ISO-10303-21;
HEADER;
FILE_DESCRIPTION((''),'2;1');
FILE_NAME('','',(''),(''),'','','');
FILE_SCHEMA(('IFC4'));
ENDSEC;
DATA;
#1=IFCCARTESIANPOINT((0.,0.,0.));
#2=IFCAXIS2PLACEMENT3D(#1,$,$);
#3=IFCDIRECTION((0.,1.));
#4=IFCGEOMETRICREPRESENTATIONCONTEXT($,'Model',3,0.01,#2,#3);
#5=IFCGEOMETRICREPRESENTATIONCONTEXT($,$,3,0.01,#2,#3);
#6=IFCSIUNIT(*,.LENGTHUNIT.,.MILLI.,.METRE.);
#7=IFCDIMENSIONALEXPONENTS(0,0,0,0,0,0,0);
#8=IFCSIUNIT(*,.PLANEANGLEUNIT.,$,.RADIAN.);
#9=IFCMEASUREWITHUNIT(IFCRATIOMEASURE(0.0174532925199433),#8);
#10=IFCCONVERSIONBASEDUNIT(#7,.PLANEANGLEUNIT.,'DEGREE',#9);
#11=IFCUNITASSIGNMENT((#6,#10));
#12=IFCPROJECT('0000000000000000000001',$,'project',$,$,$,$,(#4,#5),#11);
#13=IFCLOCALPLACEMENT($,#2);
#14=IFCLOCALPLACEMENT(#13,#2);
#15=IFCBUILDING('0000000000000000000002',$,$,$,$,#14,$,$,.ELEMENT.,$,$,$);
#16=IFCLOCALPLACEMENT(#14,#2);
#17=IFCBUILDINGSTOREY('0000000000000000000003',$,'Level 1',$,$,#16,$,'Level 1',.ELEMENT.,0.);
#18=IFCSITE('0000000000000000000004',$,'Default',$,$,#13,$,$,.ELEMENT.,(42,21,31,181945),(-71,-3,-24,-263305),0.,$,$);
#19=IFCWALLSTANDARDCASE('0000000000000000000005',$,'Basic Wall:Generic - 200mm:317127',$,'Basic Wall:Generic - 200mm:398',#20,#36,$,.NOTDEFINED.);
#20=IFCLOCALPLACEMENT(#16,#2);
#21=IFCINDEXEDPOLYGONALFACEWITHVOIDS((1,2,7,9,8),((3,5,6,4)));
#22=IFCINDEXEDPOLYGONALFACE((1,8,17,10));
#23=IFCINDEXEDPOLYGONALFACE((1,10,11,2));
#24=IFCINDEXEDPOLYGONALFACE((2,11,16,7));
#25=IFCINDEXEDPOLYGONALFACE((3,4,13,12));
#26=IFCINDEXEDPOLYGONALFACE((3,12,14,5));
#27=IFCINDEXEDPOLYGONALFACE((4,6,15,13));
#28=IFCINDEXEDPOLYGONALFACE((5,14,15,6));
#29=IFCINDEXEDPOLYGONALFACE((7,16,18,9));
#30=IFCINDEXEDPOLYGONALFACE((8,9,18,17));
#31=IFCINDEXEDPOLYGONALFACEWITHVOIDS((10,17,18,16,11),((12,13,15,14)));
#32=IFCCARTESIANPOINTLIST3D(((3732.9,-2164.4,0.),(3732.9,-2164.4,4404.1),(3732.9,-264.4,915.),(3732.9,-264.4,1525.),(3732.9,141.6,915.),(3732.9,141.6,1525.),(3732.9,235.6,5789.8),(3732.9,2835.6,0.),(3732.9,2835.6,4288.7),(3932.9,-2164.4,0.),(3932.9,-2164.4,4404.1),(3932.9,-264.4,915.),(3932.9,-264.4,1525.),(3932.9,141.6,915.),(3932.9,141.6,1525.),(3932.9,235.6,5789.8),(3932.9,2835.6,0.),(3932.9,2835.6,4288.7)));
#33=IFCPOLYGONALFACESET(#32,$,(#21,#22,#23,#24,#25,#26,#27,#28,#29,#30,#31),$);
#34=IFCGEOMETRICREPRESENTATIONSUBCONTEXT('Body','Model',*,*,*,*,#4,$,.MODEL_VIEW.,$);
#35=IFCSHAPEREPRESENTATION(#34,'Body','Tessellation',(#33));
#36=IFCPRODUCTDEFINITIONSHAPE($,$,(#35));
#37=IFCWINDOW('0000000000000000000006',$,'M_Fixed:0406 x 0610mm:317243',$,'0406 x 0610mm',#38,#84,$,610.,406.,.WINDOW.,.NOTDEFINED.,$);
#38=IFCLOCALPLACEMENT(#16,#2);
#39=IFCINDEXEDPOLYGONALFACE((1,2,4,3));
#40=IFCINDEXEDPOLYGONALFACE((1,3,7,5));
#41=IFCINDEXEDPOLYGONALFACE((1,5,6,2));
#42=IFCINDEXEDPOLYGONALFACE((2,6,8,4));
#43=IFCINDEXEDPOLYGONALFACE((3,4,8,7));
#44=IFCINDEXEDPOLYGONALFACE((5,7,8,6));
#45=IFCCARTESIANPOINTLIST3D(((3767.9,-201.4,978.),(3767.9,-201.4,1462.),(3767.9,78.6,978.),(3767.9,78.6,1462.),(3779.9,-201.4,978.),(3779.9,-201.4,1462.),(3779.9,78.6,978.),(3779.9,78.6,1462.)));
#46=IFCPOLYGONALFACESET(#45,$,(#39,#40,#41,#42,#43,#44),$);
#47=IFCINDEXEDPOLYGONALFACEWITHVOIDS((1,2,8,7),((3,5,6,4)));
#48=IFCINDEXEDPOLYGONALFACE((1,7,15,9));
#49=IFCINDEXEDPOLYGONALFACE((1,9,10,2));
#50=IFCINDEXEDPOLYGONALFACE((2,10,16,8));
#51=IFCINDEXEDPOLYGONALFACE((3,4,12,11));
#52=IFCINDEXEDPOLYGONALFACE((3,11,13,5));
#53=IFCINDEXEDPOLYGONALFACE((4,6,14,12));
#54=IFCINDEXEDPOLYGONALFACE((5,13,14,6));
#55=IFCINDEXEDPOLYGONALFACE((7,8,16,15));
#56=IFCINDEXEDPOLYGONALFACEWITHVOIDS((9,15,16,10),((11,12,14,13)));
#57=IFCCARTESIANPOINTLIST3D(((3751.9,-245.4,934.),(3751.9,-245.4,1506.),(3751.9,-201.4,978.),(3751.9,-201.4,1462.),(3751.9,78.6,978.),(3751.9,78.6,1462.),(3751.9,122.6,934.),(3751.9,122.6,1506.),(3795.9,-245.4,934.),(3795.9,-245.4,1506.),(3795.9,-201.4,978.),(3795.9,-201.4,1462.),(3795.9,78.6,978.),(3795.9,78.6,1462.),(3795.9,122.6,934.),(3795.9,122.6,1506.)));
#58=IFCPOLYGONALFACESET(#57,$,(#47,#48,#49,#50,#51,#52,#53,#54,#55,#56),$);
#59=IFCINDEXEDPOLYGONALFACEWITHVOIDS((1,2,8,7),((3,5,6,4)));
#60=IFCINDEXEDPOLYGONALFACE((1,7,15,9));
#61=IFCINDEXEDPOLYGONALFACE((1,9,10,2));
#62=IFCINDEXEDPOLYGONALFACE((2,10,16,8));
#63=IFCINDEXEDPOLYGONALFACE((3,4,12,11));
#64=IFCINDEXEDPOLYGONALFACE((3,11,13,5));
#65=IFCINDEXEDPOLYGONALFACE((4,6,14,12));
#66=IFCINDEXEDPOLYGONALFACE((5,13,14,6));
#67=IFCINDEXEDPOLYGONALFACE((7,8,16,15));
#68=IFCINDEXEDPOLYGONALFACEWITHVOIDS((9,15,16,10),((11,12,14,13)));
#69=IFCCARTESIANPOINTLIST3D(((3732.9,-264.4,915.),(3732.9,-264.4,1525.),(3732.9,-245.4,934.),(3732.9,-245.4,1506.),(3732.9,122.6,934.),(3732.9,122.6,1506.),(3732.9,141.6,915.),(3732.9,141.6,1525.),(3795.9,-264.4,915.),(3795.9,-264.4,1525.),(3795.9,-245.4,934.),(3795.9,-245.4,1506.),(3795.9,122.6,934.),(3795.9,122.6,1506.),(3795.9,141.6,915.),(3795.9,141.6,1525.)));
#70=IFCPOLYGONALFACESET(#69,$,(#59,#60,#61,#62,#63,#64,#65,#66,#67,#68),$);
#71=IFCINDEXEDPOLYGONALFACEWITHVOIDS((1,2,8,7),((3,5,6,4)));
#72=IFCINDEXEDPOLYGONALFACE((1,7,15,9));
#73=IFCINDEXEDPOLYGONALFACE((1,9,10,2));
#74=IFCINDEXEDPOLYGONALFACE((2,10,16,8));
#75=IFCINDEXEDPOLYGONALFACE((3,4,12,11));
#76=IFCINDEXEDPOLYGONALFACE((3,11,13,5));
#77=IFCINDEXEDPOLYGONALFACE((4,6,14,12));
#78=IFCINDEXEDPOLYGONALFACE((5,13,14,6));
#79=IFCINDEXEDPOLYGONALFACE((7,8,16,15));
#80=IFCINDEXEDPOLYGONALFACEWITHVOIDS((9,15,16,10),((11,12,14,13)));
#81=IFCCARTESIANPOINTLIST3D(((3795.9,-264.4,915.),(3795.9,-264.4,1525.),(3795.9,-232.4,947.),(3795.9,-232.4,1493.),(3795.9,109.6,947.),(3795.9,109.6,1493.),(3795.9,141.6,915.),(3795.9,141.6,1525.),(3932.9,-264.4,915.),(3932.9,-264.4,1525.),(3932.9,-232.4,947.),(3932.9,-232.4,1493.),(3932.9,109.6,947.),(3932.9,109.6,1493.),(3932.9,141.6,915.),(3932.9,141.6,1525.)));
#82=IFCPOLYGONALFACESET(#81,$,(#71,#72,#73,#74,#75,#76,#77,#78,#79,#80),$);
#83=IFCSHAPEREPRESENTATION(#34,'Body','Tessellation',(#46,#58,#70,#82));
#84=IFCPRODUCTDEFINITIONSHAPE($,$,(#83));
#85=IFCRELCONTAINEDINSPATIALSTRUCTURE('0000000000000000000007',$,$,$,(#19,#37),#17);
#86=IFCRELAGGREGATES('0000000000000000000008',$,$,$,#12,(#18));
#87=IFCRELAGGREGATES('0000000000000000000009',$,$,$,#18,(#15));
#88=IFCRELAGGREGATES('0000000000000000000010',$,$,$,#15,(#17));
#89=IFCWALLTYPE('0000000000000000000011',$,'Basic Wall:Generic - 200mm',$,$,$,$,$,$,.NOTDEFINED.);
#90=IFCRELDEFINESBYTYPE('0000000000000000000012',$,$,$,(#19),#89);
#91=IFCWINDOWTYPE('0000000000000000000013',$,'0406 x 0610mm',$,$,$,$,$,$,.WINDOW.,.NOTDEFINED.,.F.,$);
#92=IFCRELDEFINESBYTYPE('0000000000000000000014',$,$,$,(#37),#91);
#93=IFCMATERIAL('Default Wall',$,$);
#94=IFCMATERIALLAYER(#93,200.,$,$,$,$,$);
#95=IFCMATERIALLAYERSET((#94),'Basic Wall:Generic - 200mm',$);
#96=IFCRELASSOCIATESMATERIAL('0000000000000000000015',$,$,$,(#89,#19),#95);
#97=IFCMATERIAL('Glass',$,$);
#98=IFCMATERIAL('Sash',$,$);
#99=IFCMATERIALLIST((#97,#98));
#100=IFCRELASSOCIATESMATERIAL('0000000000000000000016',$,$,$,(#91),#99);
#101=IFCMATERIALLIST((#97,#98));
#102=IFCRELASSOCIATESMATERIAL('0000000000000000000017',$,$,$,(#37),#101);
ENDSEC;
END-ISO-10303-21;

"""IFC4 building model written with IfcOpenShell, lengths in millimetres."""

from ifc_helpers import new_model, entity, si_unit, converted_unit, direction, frame, frame_2d, origin, place, context, subcontext, project, spatial, polyline, rectangle, outline, extrude, clip, bounded_halfspace, source, transform, mapped, material, material_list, layer, layer_set, layer_usage, type_object, type_shapes, element, fill, save


model = new_model("IFC4")

# Units and contexts
model_context = context("Model", 3, precision=0.01, world=origin(), true_north=direction((0.0, 1.0)))
context_of_model = context(None, 3, precision=0.01, world=origin(), true_north=direction((0.0, 1.0)))
body_context = subcontext(model_context, "Body", "Model", "MODEL_VIEW")
ifc_project = project(units=[si_unit("LENGTHUNIT", "METRE", prefix="MILLI"), converted_unit("PLANEANGLEUNIT", "DEGREE", entity("IfcRatioMeasure", 0.0174532925199433), si_unit("PLANEANGLEUNIT", "RADIAN"), dimensions=[0, 0, 0, 0, 0, 0, 0])], contexts=[model_context, context_of_model])

# Site, building, storey
site_placement = place(None, origin())
site = spatial("IfcSite", under=ifc_project, at=site_placement, Name="Default", CompositionType="ELEMENT", RefLatitude=(42, 21, 31, 181945), RefLongitude=(-71, -3, -24, -263305), RefElevation=0.0)
building_placement = place(site_placement, origin())
building = spatial("IfcBuilding", under=site, at=building_placement, CompositionType="ELEMENT")
storey_placement = place(building_placement, origin())
storey = spatial("IfcBuildingStorey", under=building, at=storey_placement, Name="Level 1", LongName="Level 1", CompositionType="ELEMENT", Elevation=0.0)

# Shared definitions
ifc_material_1 = material(Name="Default Wall")
ifc_layer = layer(ifc_material_1, 200.0)
ifc_layer_set = layer_set([ifc_layer], Name="Basic Wall:Generic - 200mm")
wall_type = type_object("IfcWallType", Name="Basic Wall:Generic - 200mm", PredefinedType="NOTDEFINED", material=ifc_layer_set)

# Wall, opening, window
ifc_layer_usage_1 = layer_usage(ifc_layer_set, "AXIS2", "NEGATIVE", 100.0)
wall_1_placement = place(storey_placement, frame((3832.9, 2835.6, 0.0), z_axis=(0.0, 0.0, 1.0), x_axis=(0.0, -1.0, 0.0)))
wall_1 = element("IfcWallStandardCase", 1, at=wall_1_placement, inside=storey, type_object=wall_type, material=ifc_layer_usage_1, Name="Basic Wall:Generic - 200mm:317127", ObjectType="Basic Wall:Generic - 200mm:398", PredefinedType="NOTDEFINED", context=body_context, shape_type="Clipping", body=[
    clip(clip(extrude(rectangle(XDim=5000.0, YDim=200.0, at=frame_2d((2500.0, 0.0), x_axis=(-1.0, 0.0))), origin(), (0.0, 0.0, 1.0), 5789.8), bounded_halfspace(frame((0.0, -100.0, 4288.7), z_axis=(-0.5, 0.0, 0.866025), x_axis=(0.0, -1.0, 0.0)), False, frame((0.0, -100.0, 4288.7)), polyline([(0.0, 0.0), (200.0, 0.0), (2600.0, 0.0), (2600.0, 200.0), (0.0, 200.0), (0.0, 0.0)]))), bounded_halfspace(frame((2600.0, -100.0, 5789.8), z_axis=(0.5, 0.0, 0.866025), x_axis=(0.0, 1.0, 0.0)), False, frame((2600.0, -100.0, 5789.8)), polyline([(0.0, 0.0), (2400.0, 0.0), (2400.0, 200.0), (0.0, 200.0), (0.0, 0.0)]))),
])
opening_1_placement = place(wall_1_placement, frame((3100.0, 100.0, 915.0)))
opening_1 = element("IfcOpeningElement", 2, at=opening_1_placement, cuts=wall_1, ObjectType="Opening", PredefinedType="OPENING", context=body_context, shape_type="SweptSolid", body=[
    extrude(rectangle(XDim=610.0, YDim=406.0, at=frame_2d((305.0, 203.0), x_axis=(1.0, 0.0))), frame((0.0, 0.0, 0.0), z_axis=(0.0, -1.0, 0.0), x_axis=(0.0, 0.0, 1.0)), (0.0, 0.0, 1.0), 200.0),
])
ifc_material_2 = material(Name="Glass")
ifc_material_3 = material(Name="Sash")
ifc_material_list_1 = material_list([ifc_material_2, ifc_material_3])
ifc_material_list_2 = material_list([ifc_material_2, ifc_material_3])
window_type = type_object("IfcWindowType", Name="0406 x 0610mm", ParameterTakesPrecedence=False, PartitioningType="NOTDEFINED", PredefinedType="WINDOW", material=ifc_material_list_2)
shared_shape_1 = source(origin(), body_context, "Body", "SweptSolid", [
    extrude(rectangle(XDim=12.0, YDim=280.0, at=frame_2d((0.0, 0.0), x_axis=(1.0, 0.0))), frame((203.0, 159.0, 63.0), z_axis=(0.0, 0.0, 1.0), x_axis=(0.0, -1.0, 0.0)), (0.0, 0.0, 1.0), 484.0),
    extrude(outline(polyline([(-184.0, -286.0), (184.0, -286.0), (184.0, 286.0), (-184.0, 286.0), (-184.0, -286.0)]), holes=[polyline([(-140.0, -242.0), (-140.0, 242.0), (140.0, 242.0), (140.0, -242.0), (-140.0, -242.0)])]), frame((203.0, 137.0, 305.0), z_axis=(0.0, 1.0, 0.0), x_axis=(1.0, 0.0, 0.0)), (0.0, 0.0, 1.0), 44.0),
    extrude(outline(polyline([(-203.0, -305.0), (203.0, -305.0), (203.0, 305.0), (-203.0, 305.0), (-203.0, -305.0)]), holes=[polyline([(-184.0, -286.0), (-184.0, 286.0), (184.0, 286.0), (184.0, -286.0), (-184.0, -286.0)])]), frame((203.0, 137.0, 305.0), z_axis=(0.0, 1.0, 0.0), x_axis=(1.0, 0.0, 0.0)), (0.0, 0.0, 1.0), 63.0),
    extrude(outline(polyline([(-203.0, -305.0), (203.0, -305.0), (203.0, 305.0), (-203.0, 305.0), (-203.0, -305.0)]), holes=[polyline([(-171.0, -273.0), (-171.0, 273.0), (171.0, 273.0), (171.0, -273.0), (-171.0, -273.0)])]), frame((203.0, 0.0, 305.0), z_axis=(0.0, 1.0, 0.0), x_axis=(1.0, 0.0, 0.0)), (0.0, 0.0, 1.0), 137.0),
])
type_shapes(window_type, [shared_shape_1])
window_placement = place(opening_1_placement, frame((0.0, 0.0, 0.0), z_axis=(0.0, 0.0, 1.0), x_axis=(-1.0, 0.0, 0.0)))
window = element("IfcWindow", 3, at=window_placement, inside=storey, type_object=window_type, material=ifc_material_list_1, Name="M_Fixed:0406 x 0610mm:317243", ObjectType="0406 x 0610mm", OverallHeight=610.0, OverallWidth=406.0, PartitioningType="NOTDEFINED", PredefinedType="WINDOW", context=body_context, shape_type="MappedRepresentation", body=[
    mapped(shared_shape_1, transform((0.0, 0.0, 0.0), scale=1.0)),
])
fill(opening_1, window)

save(model, "model.ifc")
